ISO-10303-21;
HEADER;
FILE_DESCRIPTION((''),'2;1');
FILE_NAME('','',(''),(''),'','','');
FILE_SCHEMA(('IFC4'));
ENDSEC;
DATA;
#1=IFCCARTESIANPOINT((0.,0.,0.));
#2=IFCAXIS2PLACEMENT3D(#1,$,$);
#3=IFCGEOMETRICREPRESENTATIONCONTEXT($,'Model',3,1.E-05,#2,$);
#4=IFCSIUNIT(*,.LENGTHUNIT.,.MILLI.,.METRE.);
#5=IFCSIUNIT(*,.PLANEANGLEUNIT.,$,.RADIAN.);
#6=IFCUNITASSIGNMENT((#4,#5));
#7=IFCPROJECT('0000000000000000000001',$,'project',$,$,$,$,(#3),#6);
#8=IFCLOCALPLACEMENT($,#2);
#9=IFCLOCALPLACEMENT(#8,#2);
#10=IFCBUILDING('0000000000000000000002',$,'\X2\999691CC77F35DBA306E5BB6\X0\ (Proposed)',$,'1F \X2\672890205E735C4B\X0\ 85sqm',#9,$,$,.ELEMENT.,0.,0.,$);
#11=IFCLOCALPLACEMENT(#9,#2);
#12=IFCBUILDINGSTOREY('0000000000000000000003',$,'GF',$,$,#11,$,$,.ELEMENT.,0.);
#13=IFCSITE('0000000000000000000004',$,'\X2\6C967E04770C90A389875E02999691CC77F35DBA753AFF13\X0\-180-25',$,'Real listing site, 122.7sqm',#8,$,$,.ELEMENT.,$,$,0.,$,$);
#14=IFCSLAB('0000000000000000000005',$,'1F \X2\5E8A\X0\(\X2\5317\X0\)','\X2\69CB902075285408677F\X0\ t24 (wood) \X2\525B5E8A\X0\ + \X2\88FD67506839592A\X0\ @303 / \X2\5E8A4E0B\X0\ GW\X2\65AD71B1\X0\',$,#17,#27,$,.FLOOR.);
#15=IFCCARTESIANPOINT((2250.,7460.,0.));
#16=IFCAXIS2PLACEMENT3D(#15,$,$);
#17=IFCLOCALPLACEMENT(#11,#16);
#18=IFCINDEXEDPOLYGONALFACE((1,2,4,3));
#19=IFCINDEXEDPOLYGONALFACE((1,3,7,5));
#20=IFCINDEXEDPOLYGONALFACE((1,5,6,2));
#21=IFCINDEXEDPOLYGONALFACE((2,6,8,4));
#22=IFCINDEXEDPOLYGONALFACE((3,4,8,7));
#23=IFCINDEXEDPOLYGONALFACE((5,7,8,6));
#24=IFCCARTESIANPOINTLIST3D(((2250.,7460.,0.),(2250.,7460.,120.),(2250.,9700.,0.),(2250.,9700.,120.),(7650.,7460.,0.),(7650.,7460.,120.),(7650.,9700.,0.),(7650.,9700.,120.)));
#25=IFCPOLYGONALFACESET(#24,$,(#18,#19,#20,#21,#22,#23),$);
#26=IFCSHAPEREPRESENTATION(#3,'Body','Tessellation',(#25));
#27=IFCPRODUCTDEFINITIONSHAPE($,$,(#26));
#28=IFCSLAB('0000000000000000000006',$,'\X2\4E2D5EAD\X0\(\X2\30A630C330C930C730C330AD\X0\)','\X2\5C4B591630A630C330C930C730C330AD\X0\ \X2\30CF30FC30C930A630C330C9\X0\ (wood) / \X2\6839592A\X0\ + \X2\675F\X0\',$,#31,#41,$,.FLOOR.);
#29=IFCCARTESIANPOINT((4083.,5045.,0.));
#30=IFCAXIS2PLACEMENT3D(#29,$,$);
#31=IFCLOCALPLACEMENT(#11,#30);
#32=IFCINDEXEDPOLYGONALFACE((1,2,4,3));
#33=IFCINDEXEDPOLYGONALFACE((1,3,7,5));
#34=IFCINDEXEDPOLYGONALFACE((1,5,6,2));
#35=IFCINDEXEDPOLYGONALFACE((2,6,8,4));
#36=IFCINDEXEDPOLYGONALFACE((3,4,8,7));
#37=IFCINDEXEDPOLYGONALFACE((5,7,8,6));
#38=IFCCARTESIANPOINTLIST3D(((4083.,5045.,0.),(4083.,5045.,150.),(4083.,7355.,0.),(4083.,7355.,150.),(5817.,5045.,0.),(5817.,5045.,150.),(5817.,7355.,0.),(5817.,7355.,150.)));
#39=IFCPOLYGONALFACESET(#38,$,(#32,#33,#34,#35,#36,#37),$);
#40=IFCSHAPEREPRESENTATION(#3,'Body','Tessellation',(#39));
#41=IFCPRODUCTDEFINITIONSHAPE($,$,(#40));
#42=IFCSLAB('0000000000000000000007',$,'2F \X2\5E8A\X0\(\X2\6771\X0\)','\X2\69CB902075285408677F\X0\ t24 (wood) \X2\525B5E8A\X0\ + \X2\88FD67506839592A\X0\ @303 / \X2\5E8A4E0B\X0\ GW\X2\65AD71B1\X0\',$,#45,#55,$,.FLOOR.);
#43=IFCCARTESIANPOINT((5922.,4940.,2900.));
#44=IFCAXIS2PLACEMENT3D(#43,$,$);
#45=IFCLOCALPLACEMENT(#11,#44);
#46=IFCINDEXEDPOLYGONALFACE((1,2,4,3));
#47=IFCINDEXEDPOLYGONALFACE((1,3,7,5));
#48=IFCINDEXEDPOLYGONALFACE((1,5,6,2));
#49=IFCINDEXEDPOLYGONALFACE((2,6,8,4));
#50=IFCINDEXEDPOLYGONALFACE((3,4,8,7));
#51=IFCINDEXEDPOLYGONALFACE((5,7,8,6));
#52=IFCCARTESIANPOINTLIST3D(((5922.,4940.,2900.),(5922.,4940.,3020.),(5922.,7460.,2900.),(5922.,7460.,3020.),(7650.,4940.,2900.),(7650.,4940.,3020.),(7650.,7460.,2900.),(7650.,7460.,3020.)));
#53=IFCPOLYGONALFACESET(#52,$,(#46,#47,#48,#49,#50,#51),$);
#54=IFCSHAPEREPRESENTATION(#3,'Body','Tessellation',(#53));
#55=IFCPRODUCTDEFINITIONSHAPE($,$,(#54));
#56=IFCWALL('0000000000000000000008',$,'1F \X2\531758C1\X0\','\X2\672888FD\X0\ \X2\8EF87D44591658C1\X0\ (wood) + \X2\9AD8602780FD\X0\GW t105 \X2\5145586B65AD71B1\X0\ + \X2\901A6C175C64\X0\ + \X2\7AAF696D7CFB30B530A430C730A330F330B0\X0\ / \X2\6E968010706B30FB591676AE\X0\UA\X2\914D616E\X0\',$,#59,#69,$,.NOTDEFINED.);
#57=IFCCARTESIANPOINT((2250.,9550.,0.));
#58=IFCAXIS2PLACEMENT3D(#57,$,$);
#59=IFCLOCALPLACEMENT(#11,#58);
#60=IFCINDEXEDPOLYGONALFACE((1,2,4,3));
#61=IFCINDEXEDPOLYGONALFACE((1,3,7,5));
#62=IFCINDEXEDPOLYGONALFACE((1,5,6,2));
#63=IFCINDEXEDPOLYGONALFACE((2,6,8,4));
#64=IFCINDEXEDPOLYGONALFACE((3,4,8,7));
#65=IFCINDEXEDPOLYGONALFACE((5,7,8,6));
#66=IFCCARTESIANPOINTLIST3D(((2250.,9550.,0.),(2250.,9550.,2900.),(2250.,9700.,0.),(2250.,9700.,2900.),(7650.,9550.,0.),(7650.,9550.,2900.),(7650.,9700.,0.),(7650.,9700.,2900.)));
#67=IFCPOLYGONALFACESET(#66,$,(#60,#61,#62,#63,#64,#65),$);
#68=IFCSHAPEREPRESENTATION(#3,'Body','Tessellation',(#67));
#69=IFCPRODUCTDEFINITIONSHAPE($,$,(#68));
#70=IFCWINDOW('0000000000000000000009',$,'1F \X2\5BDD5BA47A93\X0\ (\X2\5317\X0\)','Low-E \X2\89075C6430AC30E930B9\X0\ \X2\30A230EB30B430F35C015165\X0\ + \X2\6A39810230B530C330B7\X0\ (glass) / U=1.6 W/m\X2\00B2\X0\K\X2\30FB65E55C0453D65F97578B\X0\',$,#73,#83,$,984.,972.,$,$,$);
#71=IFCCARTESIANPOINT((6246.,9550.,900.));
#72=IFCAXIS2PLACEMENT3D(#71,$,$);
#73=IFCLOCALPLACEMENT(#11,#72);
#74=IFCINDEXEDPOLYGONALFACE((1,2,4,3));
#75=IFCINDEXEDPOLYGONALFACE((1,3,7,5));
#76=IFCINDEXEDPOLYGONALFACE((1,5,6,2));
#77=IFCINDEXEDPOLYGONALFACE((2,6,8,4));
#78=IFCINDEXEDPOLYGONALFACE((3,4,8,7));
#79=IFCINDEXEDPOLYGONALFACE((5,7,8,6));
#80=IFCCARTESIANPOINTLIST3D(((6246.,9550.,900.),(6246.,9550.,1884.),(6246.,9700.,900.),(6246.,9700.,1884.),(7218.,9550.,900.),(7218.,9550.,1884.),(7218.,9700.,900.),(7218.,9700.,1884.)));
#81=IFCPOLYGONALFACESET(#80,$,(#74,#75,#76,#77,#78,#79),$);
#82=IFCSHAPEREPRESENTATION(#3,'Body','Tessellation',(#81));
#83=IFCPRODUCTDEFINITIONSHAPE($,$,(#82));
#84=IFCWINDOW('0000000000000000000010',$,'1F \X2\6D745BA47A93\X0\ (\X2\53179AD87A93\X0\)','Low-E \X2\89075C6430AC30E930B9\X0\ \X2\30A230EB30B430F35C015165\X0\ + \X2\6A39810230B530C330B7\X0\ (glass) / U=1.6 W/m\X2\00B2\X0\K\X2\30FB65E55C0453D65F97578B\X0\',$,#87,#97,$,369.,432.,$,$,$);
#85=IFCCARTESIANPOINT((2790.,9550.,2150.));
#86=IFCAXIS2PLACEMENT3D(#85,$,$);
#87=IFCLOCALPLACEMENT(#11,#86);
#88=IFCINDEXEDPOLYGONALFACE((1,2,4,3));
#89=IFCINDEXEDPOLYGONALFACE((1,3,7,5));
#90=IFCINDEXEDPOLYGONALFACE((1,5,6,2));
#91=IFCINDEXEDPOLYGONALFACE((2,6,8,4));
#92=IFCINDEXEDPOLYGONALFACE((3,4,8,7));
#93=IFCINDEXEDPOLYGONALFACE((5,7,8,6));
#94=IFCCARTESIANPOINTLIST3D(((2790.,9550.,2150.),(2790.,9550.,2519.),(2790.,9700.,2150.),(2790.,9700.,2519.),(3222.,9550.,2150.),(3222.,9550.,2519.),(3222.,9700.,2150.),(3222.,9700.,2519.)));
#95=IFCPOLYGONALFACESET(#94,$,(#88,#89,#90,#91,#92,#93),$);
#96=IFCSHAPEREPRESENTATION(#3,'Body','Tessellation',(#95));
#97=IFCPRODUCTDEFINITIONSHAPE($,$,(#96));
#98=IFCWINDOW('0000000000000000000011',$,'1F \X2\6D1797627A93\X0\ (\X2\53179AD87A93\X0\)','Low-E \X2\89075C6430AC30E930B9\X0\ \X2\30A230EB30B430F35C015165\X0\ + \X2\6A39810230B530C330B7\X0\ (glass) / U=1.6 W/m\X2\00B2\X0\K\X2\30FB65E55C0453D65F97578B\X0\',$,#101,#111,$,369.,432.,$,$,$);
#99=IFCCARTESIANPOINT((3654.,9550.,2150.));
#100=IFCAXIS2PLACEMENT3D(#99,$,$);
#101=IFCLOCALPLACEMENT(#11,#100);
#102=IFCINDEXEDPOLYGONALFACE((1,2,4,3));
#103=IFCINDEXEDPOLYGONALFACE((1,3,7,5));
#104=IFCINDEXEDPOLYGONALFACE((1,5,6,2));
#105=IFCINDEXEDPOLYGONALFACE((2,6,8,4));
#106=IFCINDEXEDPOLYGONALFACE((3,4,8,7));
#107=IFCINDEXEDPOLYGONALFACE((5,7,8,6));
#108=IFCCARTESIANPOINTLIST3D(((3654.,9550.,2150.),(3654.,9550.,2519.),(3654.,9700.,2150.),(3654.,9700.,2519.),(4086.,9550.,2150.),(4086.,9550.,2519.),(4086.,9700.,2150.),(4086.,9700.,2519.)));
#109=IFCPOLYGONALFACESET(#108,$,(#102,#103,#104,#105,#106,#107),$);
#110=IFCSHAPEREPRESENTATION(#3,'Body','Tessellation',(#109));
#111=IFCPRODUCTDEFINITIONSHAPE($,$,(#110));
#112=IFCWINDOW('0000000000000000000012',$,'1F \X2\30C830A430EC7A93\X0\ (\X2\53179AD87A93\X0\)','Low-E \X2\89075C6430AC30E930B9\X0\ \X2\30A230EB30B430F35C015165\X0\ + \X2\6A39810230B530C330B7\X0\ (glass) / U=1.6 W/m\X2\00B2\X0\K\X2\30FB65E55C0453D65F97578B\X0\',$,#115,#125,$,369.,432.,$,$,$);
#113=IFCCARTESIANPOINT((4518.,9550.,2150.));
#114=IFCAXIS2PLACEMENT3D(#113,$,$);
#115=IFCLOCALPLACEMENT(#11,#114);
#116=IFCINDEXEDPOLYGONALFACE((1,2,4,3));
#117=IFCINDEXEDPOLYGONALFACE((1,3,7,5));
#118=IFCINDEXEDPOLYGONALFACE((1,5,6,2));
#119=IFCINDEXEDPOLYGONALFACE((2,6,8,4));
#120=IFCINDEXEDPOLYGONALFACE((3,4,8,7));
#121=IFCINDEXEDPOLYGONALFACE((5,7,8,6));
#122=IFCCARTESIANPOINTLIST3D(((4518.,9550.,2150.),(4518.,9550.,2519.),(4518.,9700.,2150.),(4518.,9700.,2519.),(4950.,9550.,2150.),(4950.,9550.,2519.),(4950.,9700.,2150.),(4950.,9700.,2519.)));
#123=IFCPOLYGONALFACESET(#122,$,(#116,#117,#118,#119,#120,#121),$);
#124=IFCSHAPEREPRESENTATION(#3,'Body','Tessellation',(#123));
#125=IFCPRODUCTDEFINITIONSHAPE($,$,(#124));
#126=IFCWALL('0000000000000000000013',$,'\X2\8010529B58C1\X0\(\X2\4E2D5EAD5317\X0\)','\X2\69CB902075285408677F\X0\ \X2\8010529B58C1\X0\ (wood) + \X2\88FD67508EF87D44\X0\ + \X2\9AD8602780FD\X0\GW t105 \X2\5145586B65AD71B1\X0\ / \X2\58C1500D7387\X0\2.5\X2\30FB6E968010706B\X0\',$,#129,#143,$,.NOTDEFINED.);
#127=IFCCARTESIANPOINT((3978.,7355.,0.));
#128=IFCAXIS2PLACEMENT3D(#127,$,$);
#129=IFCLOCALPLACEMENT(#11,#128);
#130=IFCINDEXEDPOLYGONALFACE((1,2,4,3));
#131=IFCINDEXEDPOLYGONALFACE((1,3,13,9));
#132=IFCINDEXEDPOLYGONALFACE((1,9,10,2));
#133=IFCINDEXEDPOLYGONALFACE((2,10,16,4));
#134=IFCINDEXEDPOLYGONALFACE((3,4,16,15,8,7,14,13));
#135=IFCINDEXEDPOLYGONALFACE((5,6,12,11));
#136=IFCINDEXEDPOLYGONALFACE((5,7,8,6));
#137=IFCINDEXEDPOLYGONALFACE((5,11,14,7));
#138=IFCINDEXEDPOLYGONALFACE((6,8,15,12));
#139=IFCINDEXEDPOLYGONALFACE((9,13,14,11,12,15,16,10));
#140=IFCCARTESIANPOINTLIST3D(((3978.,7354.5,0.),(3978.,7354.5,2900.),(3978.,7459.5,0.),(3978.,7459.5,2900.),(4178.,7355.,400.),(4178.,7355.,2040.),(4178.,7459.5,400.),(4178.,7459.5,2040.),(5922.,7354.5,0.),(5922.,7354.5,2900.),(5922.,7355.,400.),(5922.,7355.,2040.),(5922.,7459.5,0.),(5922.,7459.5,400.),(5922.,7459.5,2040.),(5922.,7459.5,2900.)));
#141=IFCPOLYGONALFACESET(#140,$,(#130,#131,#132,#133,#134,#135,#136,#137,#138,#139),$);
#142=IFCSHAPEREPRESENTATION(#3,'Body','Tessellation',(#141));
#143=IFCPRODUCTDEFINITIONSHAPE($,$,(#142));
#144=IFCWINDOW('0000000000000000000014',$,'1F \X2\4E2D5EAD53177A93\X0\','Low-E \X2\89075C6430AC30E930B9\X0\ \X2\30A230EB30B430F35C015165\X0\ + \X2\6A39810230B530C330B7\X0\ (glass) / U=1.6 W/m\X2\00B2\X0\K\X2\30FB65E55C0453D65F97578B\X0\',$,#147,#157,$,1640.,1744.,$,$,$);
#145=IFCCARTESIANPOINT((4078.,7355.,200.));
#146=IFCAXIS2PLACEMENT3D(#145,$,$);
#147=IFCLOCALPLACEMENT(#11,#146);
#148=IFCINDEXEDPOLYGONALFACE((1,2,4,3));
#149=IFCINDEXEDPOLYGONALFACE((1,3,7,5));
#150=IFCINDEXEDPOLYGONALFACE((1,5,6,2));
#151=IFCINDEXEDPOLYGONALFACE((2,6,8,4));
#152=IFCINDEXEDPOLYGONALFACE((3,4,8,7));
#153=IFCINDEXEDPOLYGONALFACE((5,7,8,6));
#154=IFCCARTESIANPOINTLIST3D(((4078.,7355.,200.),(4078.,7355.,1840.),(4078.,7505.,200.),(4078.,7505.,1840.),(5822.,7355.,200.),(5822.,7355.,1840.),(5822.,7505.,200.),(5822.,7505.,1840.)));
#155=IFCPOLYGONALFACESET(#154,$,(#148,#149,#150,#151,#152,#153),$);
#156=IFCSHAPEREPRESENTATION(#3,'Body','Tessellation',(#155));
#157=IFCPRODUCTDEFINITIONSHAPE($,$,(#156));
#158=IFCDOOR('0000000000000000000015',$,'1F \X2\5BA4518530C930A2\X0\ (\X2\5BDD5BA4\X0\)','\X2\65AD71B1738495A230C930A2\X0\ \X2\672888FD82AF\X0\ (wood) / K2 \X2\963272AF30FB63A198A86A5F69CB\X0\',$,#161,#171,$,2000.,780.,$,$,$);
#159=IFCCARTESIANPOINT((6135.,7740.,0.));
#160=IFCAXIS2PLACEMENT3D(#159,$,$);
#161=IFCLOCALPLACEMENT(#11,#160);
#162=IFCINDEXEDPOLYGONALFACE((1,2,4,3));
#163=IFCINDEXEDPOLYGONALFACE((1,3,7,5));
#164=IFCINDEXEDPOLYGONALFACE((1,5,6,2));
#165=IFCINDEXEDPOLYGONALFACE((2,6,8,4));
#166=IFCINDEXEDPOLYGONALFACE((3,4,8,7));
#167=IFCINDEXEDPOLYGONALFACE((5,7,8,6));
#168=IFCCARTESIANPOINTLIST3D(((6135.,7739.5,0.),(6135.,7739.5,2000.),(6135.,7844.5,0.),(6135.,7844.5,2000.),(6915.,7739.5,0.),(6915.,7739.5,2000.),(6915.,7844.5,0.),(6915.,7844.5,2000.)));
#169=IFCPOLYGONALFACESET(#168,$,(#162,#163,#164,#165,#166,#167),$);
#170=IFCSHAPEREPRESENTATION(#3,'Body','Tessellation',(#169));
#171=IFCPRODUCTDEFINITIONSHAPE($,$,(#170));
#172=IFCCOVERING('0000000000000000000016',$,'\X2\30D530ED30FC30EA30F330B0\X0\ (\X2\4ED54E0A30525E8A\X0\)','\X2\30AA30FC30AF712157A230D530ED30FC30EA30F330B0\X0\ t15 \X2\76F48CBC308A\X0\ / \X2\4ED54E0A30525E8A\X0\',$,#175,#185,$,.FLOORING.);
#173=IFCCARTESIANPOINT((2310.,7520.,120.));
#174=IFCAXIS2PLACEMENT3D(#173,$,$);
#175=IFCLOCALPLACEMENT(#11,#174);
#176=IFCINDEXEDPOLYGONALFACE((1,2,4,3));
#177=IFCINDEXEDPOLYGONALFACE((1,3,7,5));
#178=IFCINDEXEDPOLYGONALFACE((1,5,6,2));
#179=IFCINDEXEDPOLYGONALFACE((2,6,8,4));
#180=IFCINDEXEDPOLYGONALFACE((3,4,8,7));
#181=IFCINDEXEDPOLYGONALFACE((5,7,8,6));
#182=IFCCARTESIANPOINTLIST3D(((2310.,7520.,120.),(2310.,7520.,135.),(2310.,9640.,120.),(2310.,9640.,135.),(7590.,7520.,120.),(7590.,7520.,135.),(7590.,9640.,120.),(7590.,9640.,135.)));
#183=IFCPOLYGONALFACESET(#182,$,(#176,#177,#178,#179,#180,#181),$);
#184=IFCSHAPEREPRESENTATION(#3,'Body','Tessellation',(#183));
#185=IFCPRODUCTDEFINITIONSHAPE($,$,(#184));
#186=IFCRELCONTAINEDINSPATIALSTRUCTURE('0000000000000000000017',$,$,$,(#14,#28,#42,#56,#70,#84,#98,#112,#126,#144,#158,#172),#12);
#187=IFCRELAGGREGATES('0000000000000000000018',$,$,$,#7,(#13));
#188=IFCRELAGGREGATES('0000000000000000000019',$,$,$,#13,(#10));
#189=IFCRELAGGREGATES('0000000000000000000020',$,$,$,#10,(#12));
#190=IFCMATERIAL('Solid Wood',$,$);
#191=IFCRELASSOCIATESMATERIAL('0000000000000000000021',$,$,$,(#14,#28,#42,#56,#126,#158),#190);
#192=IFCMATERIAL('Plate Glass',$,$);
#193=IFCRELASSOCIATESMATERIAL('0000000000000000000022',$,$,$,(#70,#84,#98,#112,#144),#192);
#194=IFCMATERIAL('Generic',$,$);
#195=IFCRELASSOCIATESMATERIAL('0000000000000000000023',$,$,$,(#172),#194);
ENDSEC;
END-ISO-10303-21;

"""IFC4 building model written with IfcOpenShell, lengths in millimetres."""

from ifc_helpers import new_model, si_unit, frame, frame_2d, origin, place, context, project, spatial, rectangle, extrude, material, element, fill, save


model = new_model("IFC4")

# Units and contexts
model_context = context("Model", 3, precision=1e-05, world=origin())
ifc_project = project(units=[si_unit("LENGTHUNIT", "METRE", prefix="MILLI"), si_unit("PLANEANGLEUNIT", "RADIAN")], contexts=[model_context])

# Site, building, storey
site_placement = place(None, origin())
site = spatial("IfcSite", under=ifc_project, at=site_placement, Name="沖縄県那覇市首里石嶺町３-180-25", ObjectType="Real listing site, 122.7sqm", CompositionType="ELEMENT", RefElevation=0.0)
building_placement = place(site_placement, origin())
building = spatial("IfcBuilding", under=site, at=building_placement, Name="首里石嶺の家 (Proposed)", ObjectType="1F 木造平屋 85sqm", CompositionType="ELEMENT", ElevationOfRefHeight=0.0, ElevationOfTerrain=0.0)
storey_placement = place(building_placement, origin())
storey = spatial("IfcBuildingStorey", under=building, at=storey_placement, Name="GF", CompositionType="ELEMENT", Elevation=0.0)

# Slabs
ifc_material_1 = material(Name="Solid Wood")
slab_1_placement = place(storey_placement, frame((2250.0, 7460.0, 0.0)))
element("IfcSlab", 1, at=slab_1_placement, inside=storey, material=ifc_material_1, Name="1F 床(北)", Description="構造用合板 t24 (wood) 剛床 + 製材根太 @303 / 床下 GW断熱", PredefinedType="FLOOR", context=model_context, shape_type="SweptSolid", body=[
    extrude(rectangle(XDim=5400.0, YDim=2240.0, at=frame_2d((2700.0, 1120.0))), frame((2250.0, 7460.0, 0.0)), (0.0, 0.0, 1.0), 120.0),
])
slab_2_placement = place(storey_placement, frame((4083.0, 5045.0, 0.0)))
element("IfcSlab", 2, at=slab_2_placement, inside=storey, material=ifc_material_1, Name="中庭(ウッドデッキ)", Description="屋外ウッドデッキ ハードウッド (wood) / 根太 + 束", PredefinedType="FLOOR", context=model_context, shape_type="SweptSolid", body=[
    extrude(rectangle(XDim=1734.0, YDim=2310.0, at=frame_2d((867.0, 1155.0))), frame((4083.0, 5045.0, 0.0)), (0.0, 0.0, 1.0), 150.0),
])
slab_3_placement = place(storey_placement, frame((5922.0, 4940.0, 2900.0)))
element("IfcSlab", 3, at=slab_3_placement, inside=storey, material=ifc_material_1, Name="2F 床(東)", Description="構造用合板 t24 (wood) 剛床 + 製材根太 @303 / 床下 GW断熱", PredefinedType="FLOOR", context=model_context, shape_type="SweptSolid", body=[
    extrude(rectangle(XDim=1728.0, YDim=2520.0, at=frame_2d((864.0, 1260.0))), frame((5922.0, 4940.0, 2900.0)), (0.0, 0.0, 1.0), 120.0),
])

# Wall, openings, windows
wall_1_placement = place(storey_placement, frame((2250.0, 9550.0, 0.0)))
wall_1 = element("IfcWall", 4, at=wall_1_placement, inside=storey, material=ifc_material_1, Name="1F 北壁", Description="木製 軸組外壁 (wood) + 高性能GW t105 充填断熱 + 通気層 + 窯業系サイディング / 準耐火・外皮UA配慮", PredefinedType="NOTDEFINED", context=model_context, shape_type="SweptSolid", body=[
    extrude(rectangle(XDim=5400.0, YDim=150.0, at=frame_2d((2700.0, 75.0))), frame((2250.0, 9550.0, 0.0)), (0.0, 0.0, 1.0), 2900.0),
])
opening_1_placement = place(storey_placement, frame((6246.0, 9550.0, 900.0)))
opening_1 = element("IfcOpeningElement", 5, at=opening_1_placement, cuts=wall_1, PredefinedType="NOTDEFINED", context=model_context, shape_type="SweptSolid", body=[
    extrude(rectangle(XDim=972.0, YDim=150.0, at=frame_2d((486.0, 75.0))), frame((6246.0, 9550.0, 900.0)), (0.0, 0.0, 1.0), 984.0),
])
opening_2_placement = place(storey_placement, frame((2790.0, 9550.0, 2150.0)))
opening_2 = element("IfcOpeningElement", 6, at=opening_2_placement, cuts=wall_1, PredefinedType="NOTDEFINED", context=model_context, shape_type="SweptSolid", body=[
    extrude(rectangle(XDim=432.0, YDim=150.0, at=frame_2d((216.0, 75.0))), frame((2790.0, 9550.0, 2150.0)), (0.0, 0.0, 1.0), 369.0),
])
opening_3_placement = place(storey_placement, frame((3654.0, 9550.0, 2150.0)))
opening_3 = element("IfcOpeningElement", 7, at=opening_3_placement, cuts=wall_1, PredefinedType="NOTDEFINED", context=model_context, shape_type="SweptSolid", body=[
    extrude(rectangle(XDim=432.0, YDim=150.0, at=frame_2d((216.0, 75.0))), frame((3654.0, 9550.0, 2150.0)), (0.0, 0.0, 1.0), 369.0),
])
opening_4_placement = place(storey_placement, frame((4518.0, 9550.0, 2150.0)))
opening_4 = element("IfcOpeningElement", 8, at=opening_4_placement, cuts=wall_1, PredefinedType="NOTDEFINED", context=model_context, shape_type="SweptSolid", body=[
    extrude(rectangle(XDim=432.0, YDim=150.0, at=frame_2d((216.0, 75.0))), frame((4518.0, 9550.0, 2150.0)), (0.0, 0.0, 1.0), 369.0),
])
ifc_material_2 = material(Name="Plate Glass")
window_1_placement = place(storey_placement, frame((6246.0, 9550.0, 900.0)))
window_1 = element("IfcWindow", 9, at=window_1_placement, inside=storey, material=ifc_material_2, Name="1F 寝室窓 (北)", Description="Low-E 複層ガラス アルゴン封入 + 樹脂サッシ (glass) / U=1.6 W/m²K・日射取得型", OverallHeight=984.0, OverallWidth=972.0, context=model_context, shape_type="SweptSolid", body=[
    extrude(rectangle(XDim=972.0, YDim=150.0, at=frame_2d((486.0, 75.0))), frame((6246.0, 9550.0, 900.0)), (0.0, 0.0, 1.0), 984.0),
])
fill(opening_1, window_1)
window_2_placement = place(storey_placement, frame((2790.0, 9550.0, 2150.0)))
window_2 = element("IfcWindow", 10, at=window_2_placement, inside=storey, material=ifc_material_2, Name="1F 浴室窓 (北高窓)", Description="Low-E 複層ガラス アルゴン封入 + 樹脂サッシ (glass) / U=1.6 W/m²K・日射取得型", OverallHeight=369.0, OverallWidth=432.0, context=model_context, shape_type="SweptSolid", body=[
    extrude(rectangle(XDim=432.0, YDim=150.0, at=frame_2d((216.0, 75.0))), frame((2790.0, 9550.0, 2150.0)), (0.0, 0.0, 1.0), 369.0),
])
fill(opening_2, window_2)
window_3_placement = place(storey_placement, frame((3654.0, 9550.0, 2150.0)))
window_3 = element("IfcWindow", 11, at=window_3_placement, inside=storey, material=ifc_material_2, Name="1F 洗面窓 (北高窓)", Description="Low-E 複層ガラス アルゴン封入 + 樹脂サッシ (glass) / U=1.6 W/m²K・日射取得型", OverallHeight=369.0, OverallWidth=432.0, context=model_context, shape_type="SweptSolid", body=[
    extrude(rectangle(XDim=432.0, YDim=150.0, at=frame_2d((216.0, 75.0))), frame((3654.0, 9550.0, 2150.0)), (0.0, 0.0, 1.0), 369.0),
])
fill(opening_3, window_3)
window_4_placement = place(storey_placement, frame((4518.0, 9550.0, 2150.0)))
window_4 = element("IfcWindow", 12, at=window_4_placement, inside=storey, material=ifc_material_2, Name="1F トイレ窓 (北高窓)", Description="Low-E 複層ガラス アルゴン封入 + 樹脂サッシ (glass) / U=1.6 W/m²K・日射取得型", OverallHeight=369.0, OverallWidth=432.0, context=model_context, shape_type="SweptSolid", body=[
    extrude(rectangle(XDim=432.0, YDim=150.0, at=frame_2d((216.0, 75.0))), frame((4518.0, 9550.0, 2150.0)), (0.0, 0.0, 1.0), 369.0),
])
fill(opening_4, window_4)

# Wall, opening, window
wall_2_placement = place(storey_placement, frame((3978.0, 7355.0, 0.0)))
wall_2 = element("IfcWall", 13, at=wall_2_placement, inside=storey, material=ifc_material_1, Name="耐力壁(中庭北)", Description="構造用合板 耐力壁 (wood) + 製材軸組 + 高性能GW t105 充填断熱 / 壁倍率2.5・準耐火", PredefinedType="NOTDEFINED", context=model_context, shape_type="SweptSolid", body=[
    extrude(rectangle(XDim=1944.0, YDim=105.0, at=frame_2d((972.0, 52.0))), frame((3978.0, 7355.0, 0.0)), (0.0, 0.0, 1.0), 2900.0),
])
opening_5_placement = place(storey_placement, frame((4078.0, 7355.0, 200.0)))
opening_5 = element("IfcOpeningElement", 14, at=opening_5_placement, cuts=wall_2, PredefinedType="NOTDEFINED", context=model_context, shape_type="SweptSolid", body=[
    extrude(rectangle(XDim=1744.0, YDim=150.0, at=frame_2d((872.0, 75.0))), frame((4078.0, 7355.0, 200.0)), (0.0, 0.0, 1.0), 1640.0),
])
window_5_placement = place(storey_placement, frame((4078.0, 7355.0, 200.0)))
window_5 = element("IfcWindow", 15, at=window_5_placement, inside=storey, material=ifc_material_2, Name="1F 中庭北窓", Description="Low-E 複層ガラス アルゴン封入 + 樹脂サッシ (glass) / U=1.6 W/m²K・日射取得型", OverallHeight=1640.0, OverallWidth=1744.0, context=model_context, shape_type="SweptSolid", body=[
    extrude(rectangle(XDim=1744.0, YDim=150.0, at=frame_2d((872.0, 75.0))), frame((4078.0, 7355.0, 200.0)), (0.0, 0.0, 1.0), 1640.0),
])
fill(opening_5, window_5)

# Door
door_1_placement = place(storey_placement, frame((6135.0, 7740.0, 0.0)))
element("IfcDoor", 16, at=door_1_placement, inside=storey, material=ifc_material_1, Name="1F 室内ドア (寝室)", Description="断熱玄関ドア 木製芯 (wood) / K2 防犯・採風機構", OverallHeight=2000.0, OverallWidth=780.0, context=model_context, shape_type="SweptSolid", body=[
    extrude(rectangle(XDim=780.0, YDim=105.0, at=frame_2d((390.0, 52.0))), frame((6135.0, 7740.0, 0.0)), (0.0, 0.0, 1.0), 2000.0),
])

# Covering
ifc_material_3 = material(Name="Generic")
covering_1_placement = place(storey_placement, frame((2310.0, 7520.0, 120.0)))
element("IfcCovering", 17, at=covering_1_placement, inside=storey, material=ifc_material_3, Name="フローリング (仕上げ床)", Description="オーク無垢フローリング t15 直貼り / 仕上げ床", PredefinedType="FLOORING", context=model_context, shape_type="SweptSolid", body=[
    extrude(rectangle(XDim=5280.0, YDim=2120.0, at=frame_2d((2640.0, 1060.0))), frame((2310.0, 7520.0, 120.0)), (0.0, 0.0, 1.0), 15.0),
])

save(model, "model.ifc")
